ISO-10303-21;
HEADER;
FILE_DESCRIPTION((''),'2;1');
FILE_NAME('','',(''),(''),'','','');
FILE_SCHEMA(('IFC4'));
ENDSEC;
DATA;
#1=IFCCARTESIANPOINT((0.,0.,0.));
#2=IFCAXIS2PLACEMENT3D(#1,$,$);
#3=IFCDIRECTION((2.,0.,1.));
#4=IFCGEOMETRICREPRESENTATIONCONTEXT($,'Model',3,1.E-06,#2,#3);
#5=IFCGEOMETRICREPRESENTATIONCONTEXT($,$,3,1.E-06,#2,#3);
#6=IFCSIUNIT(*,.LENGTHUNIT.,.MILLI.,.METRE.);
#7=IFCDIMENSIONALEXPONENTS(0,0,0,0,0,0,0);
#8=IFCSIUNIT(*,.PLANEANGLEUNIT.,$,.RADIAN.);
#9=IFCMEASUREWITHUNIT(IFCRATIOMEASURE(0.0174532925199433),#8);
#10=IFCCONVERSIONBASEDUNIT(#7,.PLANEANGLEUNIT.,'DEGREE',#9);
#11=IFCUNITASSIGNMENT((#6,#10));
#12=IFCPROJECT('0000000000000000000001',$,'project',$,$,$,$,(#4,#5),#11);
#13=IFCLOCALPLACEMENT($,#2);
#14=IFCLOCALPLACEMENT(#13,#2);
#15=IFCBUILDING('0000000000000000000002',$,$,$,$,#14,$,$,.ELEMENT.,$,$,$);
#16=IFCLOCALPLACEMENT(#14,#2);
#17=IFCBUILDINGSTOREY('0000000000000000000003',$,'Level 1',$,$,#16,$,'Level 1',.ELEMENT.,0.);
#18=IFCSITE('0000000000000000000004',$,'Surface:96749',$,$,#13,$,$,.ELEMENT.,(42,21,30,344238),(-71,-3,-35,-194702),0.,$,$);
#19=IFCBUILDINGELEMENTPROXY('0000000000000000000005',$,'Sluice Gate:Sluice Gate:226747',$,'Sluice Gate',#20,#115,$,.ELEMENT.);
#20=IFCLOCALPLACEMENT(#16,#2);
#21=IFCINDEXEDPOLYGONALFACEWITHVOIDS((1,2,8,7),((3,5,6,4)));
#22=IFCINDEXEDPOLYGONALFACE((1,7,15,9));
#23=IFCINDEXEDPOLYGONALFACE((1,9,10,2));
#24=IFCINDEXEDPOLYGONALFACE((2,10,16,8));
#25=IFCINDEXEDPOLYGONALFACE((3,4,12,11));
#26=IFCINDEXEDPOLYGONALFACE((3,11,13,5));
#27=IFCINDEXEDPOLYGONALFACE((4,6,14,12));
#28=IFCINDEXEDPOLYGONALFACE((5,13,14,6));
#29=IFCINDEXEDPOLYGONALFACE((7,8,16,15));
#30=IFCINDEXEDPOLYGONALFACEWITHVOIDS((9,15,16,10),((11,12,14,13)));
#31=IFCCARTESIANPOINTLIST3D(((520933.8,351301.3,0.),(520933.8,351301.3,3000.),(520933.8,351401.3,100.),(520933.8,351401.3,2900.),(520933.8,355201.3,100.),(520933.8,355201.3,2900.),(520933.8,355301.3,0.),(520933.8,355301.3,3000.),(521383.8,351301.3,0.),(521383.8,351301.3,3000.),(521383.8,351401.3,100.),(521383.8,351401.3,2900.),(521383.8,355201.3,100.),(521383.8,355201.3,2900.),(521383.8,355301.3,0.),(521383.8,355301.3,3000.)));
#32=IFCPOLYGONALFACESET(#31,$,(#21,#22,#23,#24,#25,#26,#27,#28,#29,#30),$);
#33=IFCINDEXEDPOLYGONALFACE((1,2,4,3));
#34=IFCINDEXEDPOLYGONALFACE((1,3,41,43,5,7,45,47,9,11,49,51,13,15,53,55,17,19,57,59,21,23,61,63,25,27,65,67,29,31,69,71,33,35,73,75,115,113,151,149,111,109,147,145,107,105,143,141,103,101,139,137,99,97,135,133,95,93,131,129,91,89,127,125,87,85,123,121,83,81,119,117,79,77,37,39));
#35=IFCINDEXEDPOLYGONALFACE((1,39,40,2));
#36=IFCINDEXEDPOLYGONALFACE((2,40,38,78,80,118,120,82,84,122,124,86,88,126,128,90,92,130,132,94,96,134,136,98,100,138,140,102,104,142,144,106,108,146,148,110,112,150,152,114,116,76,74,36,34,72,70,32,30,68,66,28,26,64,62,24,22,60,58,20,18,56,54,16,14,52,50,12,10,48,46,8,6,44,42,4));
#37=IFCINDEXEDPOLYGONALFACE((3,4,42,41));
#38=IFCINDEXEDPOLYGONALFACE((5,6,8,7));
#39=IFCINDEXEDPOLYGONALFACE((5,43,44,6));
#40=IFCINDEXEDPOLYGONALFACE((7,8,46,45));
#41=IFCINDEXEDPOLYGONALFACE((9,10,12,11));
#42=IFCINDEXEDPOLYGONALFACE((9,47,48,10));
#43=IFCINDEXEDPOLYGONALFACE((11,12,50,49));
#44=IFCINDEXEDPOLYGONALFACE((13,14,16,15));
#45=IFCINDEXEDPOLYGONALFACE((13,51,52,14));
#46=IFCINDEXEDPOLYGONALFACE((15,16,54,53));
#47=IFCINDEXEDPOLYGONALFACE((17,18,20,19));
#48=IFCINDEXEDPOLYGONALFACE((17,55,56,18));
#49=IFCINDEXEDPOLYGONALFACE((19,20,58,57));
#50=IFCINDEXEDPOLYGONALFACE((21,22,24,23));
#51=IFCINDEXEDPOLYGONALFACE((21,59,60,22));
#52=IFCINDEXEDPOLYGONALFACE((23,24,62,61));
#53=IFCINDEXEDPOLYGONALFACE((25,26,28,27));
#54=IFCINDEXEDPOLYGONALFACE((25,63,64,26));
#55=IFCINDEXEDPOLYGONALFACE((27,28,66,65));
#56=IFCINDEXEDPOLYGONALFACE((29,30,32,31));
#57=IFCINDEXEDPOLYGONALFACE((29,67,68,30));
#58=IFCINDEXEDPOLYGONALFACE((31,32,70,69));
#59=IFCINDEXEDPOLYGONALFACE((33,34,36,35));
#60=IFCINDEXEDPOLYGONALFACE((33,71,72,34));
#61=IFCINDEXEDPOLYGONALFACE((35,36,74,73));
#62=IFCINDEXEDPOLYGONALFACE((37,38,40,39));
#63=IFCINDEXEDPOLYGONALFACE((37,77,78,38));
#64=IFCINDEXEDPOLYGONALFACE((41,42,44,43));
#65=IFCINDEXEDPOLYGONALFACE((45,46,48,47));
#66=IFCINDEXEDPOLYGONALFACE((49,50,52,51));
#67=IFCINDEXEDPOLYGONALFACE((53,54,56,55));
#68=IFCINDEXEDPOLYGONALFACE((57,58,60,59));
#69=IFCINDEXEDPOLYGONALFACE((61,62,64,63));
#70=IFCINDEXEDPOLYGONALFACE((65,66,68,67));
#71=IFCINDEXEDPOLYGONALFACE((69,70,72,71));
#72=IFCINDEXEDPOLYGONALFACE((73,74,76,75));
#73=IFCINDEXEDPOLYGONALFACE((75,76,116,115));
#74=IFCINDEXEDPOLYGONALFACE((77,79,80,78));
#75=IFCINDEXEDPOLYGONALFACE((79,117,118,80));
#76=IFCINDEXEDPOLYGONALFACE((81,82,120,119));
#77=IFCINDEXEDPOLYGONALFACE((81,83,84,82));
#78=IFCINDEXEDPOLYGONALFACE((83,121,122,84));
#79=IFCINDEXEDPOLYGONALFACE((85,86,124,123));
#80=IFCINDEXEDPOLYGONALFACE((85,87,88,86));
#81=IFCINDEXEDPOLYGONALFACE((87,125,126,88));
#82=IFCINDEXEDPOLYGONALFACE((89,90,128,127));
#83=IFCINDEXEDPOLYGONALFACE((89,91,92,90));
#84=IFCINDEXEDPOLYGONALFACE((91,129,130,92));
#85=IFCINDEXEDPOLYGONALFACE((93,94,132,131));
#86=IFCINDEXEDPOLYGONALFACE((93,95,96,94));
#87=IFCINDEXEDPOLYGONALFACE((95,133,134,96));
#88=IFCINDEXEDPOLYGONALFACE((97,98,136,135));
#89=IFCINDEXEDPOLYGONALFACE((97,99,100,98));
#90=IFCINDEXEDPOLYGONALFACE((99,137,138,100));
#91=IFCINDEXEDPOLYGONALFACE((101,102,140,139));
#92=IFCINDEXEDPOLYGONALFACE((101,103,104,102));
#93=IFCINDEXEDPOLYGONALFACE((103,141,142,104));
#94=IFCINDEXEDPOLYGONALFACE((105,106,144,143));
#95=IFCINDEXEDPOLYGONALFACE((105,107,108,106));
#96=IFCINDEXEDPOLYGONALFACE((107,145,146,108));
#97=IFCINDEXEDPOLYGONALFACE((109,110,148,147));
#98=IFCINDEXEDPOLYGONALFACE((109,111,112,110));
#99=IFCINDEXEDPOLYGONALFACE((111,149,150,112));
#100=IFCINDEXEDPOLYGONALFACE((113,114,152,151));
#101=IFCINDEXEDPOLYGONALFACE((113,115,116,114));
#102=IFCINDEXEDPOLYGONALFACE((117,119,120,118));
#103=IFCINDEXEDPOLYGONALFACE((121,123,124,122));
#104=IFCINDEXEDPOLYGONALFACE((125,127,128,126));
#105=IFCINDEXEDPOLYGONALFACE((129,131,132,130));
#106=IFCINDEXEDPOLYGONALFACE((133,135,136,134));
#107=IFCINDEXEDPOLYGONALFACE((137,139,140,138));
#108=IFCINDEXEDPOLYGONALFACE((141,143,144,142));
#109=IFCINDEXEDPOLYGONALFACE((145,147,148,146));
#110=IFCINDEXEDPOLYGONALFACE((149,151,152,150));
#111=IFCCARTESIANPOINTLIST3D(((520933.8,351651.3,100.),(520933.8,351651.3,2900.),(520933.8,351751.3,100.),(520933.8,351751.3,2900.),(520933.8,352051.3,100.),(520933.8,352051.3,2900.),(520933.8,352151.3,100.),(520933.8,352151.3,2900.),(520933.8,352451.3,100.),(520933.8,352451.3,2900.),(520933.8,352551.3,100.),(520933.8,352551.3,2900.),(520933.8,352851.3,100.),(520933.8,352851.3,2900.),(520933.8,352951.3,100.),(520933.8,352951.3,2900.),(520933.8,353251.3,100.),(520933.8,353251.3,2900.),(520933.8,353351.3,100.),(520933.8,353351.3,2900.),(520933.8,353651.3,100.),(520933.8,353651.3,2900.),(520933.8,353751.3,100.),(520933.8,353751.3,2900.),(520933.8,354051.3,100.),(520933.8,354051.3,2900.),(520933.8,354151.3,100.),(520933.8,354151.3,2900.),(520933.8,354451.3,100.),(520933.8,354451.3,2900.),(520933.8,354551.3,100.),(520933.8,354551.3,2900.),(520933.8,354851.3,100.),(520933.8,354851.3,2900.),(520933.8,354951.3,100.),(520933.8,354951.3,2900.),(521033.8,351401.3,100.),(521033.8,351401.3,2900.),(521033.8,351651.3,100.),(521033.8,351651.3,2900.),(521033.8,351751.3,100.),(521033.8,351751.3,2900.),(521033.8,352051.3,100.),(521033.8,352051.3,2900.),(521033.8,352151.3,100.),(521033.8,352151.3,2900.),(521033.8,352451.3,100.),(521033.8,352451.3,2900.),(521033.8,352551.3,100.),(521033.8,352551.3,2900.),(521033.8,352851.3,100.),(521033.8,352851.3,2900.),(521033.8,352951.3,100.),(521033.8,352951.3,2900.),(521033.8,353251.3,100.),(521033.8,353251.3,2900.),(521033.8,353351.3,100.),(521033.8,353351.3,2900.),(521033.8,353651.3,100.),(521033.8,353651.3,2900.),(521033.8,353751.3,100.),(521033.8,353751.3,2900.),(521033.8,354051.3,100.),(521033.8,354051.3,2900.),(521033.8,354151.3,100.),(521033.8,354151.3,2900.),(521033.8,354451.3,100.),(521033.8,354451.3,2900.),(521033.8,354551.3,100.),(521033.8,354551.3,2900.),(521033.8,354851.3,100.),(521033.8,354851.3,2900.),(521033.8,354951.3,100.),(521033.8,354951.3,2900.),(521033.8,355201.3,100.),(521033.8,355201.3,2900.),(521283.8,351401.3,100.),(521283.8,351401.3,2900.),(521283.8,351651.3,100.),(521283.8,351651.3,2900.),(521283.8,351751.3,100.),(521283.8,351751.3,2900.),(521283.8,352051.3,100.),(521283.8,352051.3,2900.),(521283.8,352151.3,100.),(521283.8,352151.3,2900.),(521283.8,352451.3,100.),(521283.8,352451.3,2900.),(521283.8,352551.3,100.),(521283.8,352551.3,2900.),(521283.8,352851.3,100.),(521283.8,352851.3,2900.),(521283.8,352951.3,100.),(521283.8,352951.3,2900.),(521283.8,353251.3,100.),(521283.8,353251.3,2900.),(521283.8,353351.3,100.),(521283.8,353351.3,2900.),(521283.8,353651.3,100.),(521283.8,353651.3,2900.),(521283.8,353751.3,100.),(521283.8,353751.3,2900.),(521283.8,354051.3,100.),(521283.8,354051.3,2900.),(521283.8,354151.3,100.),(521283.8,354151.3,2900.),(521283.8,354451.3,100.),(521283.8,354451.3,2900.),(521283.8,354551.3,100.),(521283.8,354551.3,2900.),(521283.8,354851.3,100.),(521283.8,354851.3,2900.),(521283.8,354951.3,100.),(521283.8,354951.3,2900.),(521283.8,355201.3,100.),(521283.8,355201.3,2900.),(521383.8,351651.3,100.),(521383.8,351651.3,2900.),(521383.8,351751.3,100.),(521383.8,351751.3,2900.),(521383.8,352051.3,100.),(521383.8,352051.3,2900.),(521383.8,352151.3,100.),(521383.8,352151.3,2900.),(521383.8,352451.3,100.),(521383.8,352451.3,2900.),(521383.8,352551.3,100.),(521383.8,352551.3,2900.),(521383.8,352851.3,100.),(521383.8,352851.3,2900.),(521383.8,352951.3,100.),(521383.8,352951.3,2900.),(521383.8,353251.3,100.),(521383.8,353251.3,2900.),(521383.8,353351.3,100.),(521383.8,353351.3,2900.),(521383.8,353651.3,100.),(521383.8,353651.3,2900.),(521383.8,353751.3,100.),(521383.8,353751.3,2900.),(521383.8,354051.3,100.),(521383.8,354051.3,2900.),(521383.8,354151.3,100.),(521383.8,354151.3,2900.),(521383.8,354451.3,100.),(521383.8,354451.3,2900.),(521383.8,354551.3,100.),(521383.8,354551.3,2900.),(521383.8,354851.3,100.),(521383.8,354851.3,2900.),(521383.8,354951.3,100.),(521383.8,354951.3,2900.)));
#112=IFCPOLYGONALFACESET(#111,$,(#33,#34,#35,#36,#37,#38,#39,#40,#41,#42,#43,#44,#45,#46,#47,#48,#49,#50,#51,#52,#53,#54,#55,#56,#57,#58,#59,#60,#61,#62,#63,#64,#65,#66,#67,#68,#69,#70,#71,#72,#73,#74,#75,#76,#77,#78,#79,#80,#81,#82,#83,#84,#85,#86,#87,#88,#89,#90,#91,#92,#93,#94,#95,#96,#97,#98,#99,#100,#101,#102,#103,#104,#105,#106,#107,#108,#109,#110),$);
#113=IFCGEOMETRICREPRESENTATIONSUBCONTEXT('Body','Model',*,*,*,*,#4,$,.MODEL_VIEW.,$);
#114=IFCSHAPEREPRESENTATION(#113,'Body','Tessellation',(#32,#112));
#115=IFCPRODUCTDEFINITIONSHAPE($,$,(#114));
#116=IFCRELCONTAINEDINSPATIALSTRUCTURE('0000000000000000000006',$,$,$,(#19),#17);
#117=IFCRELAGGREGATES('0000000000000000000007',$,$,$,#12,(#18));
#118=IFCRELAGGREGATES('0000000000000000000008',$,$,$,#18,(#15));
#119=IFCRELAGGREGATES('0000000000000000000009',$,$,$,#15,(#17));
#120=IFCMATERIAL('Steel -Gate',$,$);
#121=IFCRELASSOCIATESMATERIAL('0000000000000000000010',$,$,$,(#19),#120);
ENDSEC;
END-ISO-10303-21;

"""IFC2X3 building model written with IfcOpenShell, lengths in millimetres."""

from ifc_helpers import new_model, entity, si_unit, converted_unit, direction, frame, origin, place, context, subcontext, project, spatial, polyline, outline, extrude, source, transform, mapped, material, element, save


model = new_model("IFC2X3")

# Units and contexts
model_context = context("Model", 3, precision=1e-06, world=origin(), true_north=direction((2.0, 0.0, 1.0)))
context_of_model = context(None, 3, precision=1e-06, world=origin(), true_north=direction((2.0, 0.0, 1.0)))
body_context = subcontext(model_context, "Body", "Model", "MODEL_VIEW")
ifc_project = project(units=[si_unit("LENGTHUNIT", "METRE", prefix="MILLI"), converted_unit("PLANEANGLEUNIT", "DEGREE", entity("IfcRatioMeasure", 0.0174532925199433), si_unit("PLANEANGLEUNIT", "RADIAN"), dimensions=[0, 0, 0, 0, 0, 0, 0])], contexts=[model_context, context_of_model])

# Site, building, storey
site_placement = place(None, origin())
site = spatial("IfcSite", under=ifc_project, at=site_placement, Name="Surface:96749", CompositionType="ELEMENT", RefLatitude=(42, 21, 30, 344238), RefLongitude=(-71, -3, -35, -194702), RefElevation=0.0)
building_placement = place(site_placement, origin())
building = spatial("IfcBuilding", under=site, at=building_placement, CompositionType="ELEMENT")
storey_placement = place(building_placement, origin())
storey = spatial("IfcBuildingStorey", under=building, at=storey_placement, Name="Level 1", LongName="Level 1", CompositionType="ELEMENT", Elevation=0.0)

# Building element proxy
ifc_material = material(Name="Steel -Gate")
shared_shape_1 = source(origin(), body_context, "Body", "SweptSolid", [
    extrude(outline(polyline([(-1500.0, -2000.0), (1500.0, -2000.0), (1500.0, 2000.0), (-1500.0, 2000.0), (-1500.0, -2000.0)]), holes=[polyline([(1400.0, -1900.0), (-1400.0, -1900.0), (-1400.0, 1900.0), (1400.0, 1900.0), (1400.0, -1900.0)])]), frame((0.0, -225.0, 1500.0), z_axis=(0.0, 1.0, 0.0), x_axis=(0.0, 0.0, -1.0)), (0.0, 0.0, 1.0), 450.0),
    extrude(outline(polyline([(1650.0, -125.0), (1900.0, -125.0), (1900.0, 125.0), (1650.0, 125.0), (1650.0, 225.0), (1550.0, 225.0), (1550.0, 125.0), (1250.0, 125.0), (1250.0, 225.0), (1150.0, 225.0), (1150.0, 125.0), (850.0, 125.0), (850.0, 225.0), (750.0, 225.0), (750.0, 125.0), (450.0, 125.0), (450.0, 225.0), (350.0, 225.0), (350.0, 125.0), (50.0, 125.0), (50.0, 225.0), (-50.0, 225.0), (-50.0, 125.0), (-350.0, 125.0), (-350.0, 225.0), (-450.0, 225.0), (-450.0, 125.0), (-750.0, 125.0), (-750.0, 225.0), (-850.0, 225.0), (-850.0, 125.0), (-1150.0, 125.0), (-1150.0, 225.0), (-1250.0, 225.0), (-1250.0, 125.0), (-1550.0, 125.0), (-1550.0, 225.0), (-1650.0, 225.0), (-1650.0, 125.0), (-1900.0, 125.0), (-1900.0, -125.0), (-1650.0, -125.0), (-1650.0, -225.0), (-1550.0, -225.0), (-1550.0, -125.0), (-1250.0, -125.0), (-1250.0, -225.0), (-1150.0, -225.0), (-1150.0, -125.0), (-850.0, -125.0), (-850.0, -225.0), (-750.0, -225.0), (-750.0, -125.0), (-450.0, -125.0), (-450.0, -225.0), (-350.0, -225.0), (-350.0, -125.0), (-50.0, -125.0), (-50.0, -225.0), (50.0, -225.0), (50.0, -125.0), (350.0, -125.0), (350.0, -225.0), (450.0, -225.0), (450.0, -125.0), (750.0, -125.0), (750.0, -225.0), (850.0, -225.0), (850.0, -125.0), (1150.0, -125.0), (1150.0, -225.0), (1250.0, -225.0), (1250.0, -125.0), (1550.0, -125.0), (1550.0, -225.0), (1650.0, -225.0), (1650.0, -125.0)])), frame((0.0, 0.0, 100.0), z_axis=(0.0, 0.0, 1.0), x_axis=(-1.0, 0.0, 0.0)), (0.0, 0.0, 1.0), 2800.0),
])
for number, where, z_axis, x_axis, name in (
    (1, (521158.8, 353301.3, 0.0), (0.0, 0.0, 1.0), (0.0, 1.0, 0.0), "Sluice Gate:Sluice Gate:226747"),
):
    element("IfcBuildingElementProxy", number, at=place(storey_placement, frame(where, z_axis=z_axis, x_axis=x_axis)), inside=storey, material=ifc_material, Name=name, ObjectType="Sluice Gate", CompositionType="ELEMENT", context=body_context, shape_type="MappedRepresentation", body=[
        mapped(shared_shape_1, transform((0.0, 0.0, 0.0), scale=1.0)),
    ])

save(model, "model.ifc")
